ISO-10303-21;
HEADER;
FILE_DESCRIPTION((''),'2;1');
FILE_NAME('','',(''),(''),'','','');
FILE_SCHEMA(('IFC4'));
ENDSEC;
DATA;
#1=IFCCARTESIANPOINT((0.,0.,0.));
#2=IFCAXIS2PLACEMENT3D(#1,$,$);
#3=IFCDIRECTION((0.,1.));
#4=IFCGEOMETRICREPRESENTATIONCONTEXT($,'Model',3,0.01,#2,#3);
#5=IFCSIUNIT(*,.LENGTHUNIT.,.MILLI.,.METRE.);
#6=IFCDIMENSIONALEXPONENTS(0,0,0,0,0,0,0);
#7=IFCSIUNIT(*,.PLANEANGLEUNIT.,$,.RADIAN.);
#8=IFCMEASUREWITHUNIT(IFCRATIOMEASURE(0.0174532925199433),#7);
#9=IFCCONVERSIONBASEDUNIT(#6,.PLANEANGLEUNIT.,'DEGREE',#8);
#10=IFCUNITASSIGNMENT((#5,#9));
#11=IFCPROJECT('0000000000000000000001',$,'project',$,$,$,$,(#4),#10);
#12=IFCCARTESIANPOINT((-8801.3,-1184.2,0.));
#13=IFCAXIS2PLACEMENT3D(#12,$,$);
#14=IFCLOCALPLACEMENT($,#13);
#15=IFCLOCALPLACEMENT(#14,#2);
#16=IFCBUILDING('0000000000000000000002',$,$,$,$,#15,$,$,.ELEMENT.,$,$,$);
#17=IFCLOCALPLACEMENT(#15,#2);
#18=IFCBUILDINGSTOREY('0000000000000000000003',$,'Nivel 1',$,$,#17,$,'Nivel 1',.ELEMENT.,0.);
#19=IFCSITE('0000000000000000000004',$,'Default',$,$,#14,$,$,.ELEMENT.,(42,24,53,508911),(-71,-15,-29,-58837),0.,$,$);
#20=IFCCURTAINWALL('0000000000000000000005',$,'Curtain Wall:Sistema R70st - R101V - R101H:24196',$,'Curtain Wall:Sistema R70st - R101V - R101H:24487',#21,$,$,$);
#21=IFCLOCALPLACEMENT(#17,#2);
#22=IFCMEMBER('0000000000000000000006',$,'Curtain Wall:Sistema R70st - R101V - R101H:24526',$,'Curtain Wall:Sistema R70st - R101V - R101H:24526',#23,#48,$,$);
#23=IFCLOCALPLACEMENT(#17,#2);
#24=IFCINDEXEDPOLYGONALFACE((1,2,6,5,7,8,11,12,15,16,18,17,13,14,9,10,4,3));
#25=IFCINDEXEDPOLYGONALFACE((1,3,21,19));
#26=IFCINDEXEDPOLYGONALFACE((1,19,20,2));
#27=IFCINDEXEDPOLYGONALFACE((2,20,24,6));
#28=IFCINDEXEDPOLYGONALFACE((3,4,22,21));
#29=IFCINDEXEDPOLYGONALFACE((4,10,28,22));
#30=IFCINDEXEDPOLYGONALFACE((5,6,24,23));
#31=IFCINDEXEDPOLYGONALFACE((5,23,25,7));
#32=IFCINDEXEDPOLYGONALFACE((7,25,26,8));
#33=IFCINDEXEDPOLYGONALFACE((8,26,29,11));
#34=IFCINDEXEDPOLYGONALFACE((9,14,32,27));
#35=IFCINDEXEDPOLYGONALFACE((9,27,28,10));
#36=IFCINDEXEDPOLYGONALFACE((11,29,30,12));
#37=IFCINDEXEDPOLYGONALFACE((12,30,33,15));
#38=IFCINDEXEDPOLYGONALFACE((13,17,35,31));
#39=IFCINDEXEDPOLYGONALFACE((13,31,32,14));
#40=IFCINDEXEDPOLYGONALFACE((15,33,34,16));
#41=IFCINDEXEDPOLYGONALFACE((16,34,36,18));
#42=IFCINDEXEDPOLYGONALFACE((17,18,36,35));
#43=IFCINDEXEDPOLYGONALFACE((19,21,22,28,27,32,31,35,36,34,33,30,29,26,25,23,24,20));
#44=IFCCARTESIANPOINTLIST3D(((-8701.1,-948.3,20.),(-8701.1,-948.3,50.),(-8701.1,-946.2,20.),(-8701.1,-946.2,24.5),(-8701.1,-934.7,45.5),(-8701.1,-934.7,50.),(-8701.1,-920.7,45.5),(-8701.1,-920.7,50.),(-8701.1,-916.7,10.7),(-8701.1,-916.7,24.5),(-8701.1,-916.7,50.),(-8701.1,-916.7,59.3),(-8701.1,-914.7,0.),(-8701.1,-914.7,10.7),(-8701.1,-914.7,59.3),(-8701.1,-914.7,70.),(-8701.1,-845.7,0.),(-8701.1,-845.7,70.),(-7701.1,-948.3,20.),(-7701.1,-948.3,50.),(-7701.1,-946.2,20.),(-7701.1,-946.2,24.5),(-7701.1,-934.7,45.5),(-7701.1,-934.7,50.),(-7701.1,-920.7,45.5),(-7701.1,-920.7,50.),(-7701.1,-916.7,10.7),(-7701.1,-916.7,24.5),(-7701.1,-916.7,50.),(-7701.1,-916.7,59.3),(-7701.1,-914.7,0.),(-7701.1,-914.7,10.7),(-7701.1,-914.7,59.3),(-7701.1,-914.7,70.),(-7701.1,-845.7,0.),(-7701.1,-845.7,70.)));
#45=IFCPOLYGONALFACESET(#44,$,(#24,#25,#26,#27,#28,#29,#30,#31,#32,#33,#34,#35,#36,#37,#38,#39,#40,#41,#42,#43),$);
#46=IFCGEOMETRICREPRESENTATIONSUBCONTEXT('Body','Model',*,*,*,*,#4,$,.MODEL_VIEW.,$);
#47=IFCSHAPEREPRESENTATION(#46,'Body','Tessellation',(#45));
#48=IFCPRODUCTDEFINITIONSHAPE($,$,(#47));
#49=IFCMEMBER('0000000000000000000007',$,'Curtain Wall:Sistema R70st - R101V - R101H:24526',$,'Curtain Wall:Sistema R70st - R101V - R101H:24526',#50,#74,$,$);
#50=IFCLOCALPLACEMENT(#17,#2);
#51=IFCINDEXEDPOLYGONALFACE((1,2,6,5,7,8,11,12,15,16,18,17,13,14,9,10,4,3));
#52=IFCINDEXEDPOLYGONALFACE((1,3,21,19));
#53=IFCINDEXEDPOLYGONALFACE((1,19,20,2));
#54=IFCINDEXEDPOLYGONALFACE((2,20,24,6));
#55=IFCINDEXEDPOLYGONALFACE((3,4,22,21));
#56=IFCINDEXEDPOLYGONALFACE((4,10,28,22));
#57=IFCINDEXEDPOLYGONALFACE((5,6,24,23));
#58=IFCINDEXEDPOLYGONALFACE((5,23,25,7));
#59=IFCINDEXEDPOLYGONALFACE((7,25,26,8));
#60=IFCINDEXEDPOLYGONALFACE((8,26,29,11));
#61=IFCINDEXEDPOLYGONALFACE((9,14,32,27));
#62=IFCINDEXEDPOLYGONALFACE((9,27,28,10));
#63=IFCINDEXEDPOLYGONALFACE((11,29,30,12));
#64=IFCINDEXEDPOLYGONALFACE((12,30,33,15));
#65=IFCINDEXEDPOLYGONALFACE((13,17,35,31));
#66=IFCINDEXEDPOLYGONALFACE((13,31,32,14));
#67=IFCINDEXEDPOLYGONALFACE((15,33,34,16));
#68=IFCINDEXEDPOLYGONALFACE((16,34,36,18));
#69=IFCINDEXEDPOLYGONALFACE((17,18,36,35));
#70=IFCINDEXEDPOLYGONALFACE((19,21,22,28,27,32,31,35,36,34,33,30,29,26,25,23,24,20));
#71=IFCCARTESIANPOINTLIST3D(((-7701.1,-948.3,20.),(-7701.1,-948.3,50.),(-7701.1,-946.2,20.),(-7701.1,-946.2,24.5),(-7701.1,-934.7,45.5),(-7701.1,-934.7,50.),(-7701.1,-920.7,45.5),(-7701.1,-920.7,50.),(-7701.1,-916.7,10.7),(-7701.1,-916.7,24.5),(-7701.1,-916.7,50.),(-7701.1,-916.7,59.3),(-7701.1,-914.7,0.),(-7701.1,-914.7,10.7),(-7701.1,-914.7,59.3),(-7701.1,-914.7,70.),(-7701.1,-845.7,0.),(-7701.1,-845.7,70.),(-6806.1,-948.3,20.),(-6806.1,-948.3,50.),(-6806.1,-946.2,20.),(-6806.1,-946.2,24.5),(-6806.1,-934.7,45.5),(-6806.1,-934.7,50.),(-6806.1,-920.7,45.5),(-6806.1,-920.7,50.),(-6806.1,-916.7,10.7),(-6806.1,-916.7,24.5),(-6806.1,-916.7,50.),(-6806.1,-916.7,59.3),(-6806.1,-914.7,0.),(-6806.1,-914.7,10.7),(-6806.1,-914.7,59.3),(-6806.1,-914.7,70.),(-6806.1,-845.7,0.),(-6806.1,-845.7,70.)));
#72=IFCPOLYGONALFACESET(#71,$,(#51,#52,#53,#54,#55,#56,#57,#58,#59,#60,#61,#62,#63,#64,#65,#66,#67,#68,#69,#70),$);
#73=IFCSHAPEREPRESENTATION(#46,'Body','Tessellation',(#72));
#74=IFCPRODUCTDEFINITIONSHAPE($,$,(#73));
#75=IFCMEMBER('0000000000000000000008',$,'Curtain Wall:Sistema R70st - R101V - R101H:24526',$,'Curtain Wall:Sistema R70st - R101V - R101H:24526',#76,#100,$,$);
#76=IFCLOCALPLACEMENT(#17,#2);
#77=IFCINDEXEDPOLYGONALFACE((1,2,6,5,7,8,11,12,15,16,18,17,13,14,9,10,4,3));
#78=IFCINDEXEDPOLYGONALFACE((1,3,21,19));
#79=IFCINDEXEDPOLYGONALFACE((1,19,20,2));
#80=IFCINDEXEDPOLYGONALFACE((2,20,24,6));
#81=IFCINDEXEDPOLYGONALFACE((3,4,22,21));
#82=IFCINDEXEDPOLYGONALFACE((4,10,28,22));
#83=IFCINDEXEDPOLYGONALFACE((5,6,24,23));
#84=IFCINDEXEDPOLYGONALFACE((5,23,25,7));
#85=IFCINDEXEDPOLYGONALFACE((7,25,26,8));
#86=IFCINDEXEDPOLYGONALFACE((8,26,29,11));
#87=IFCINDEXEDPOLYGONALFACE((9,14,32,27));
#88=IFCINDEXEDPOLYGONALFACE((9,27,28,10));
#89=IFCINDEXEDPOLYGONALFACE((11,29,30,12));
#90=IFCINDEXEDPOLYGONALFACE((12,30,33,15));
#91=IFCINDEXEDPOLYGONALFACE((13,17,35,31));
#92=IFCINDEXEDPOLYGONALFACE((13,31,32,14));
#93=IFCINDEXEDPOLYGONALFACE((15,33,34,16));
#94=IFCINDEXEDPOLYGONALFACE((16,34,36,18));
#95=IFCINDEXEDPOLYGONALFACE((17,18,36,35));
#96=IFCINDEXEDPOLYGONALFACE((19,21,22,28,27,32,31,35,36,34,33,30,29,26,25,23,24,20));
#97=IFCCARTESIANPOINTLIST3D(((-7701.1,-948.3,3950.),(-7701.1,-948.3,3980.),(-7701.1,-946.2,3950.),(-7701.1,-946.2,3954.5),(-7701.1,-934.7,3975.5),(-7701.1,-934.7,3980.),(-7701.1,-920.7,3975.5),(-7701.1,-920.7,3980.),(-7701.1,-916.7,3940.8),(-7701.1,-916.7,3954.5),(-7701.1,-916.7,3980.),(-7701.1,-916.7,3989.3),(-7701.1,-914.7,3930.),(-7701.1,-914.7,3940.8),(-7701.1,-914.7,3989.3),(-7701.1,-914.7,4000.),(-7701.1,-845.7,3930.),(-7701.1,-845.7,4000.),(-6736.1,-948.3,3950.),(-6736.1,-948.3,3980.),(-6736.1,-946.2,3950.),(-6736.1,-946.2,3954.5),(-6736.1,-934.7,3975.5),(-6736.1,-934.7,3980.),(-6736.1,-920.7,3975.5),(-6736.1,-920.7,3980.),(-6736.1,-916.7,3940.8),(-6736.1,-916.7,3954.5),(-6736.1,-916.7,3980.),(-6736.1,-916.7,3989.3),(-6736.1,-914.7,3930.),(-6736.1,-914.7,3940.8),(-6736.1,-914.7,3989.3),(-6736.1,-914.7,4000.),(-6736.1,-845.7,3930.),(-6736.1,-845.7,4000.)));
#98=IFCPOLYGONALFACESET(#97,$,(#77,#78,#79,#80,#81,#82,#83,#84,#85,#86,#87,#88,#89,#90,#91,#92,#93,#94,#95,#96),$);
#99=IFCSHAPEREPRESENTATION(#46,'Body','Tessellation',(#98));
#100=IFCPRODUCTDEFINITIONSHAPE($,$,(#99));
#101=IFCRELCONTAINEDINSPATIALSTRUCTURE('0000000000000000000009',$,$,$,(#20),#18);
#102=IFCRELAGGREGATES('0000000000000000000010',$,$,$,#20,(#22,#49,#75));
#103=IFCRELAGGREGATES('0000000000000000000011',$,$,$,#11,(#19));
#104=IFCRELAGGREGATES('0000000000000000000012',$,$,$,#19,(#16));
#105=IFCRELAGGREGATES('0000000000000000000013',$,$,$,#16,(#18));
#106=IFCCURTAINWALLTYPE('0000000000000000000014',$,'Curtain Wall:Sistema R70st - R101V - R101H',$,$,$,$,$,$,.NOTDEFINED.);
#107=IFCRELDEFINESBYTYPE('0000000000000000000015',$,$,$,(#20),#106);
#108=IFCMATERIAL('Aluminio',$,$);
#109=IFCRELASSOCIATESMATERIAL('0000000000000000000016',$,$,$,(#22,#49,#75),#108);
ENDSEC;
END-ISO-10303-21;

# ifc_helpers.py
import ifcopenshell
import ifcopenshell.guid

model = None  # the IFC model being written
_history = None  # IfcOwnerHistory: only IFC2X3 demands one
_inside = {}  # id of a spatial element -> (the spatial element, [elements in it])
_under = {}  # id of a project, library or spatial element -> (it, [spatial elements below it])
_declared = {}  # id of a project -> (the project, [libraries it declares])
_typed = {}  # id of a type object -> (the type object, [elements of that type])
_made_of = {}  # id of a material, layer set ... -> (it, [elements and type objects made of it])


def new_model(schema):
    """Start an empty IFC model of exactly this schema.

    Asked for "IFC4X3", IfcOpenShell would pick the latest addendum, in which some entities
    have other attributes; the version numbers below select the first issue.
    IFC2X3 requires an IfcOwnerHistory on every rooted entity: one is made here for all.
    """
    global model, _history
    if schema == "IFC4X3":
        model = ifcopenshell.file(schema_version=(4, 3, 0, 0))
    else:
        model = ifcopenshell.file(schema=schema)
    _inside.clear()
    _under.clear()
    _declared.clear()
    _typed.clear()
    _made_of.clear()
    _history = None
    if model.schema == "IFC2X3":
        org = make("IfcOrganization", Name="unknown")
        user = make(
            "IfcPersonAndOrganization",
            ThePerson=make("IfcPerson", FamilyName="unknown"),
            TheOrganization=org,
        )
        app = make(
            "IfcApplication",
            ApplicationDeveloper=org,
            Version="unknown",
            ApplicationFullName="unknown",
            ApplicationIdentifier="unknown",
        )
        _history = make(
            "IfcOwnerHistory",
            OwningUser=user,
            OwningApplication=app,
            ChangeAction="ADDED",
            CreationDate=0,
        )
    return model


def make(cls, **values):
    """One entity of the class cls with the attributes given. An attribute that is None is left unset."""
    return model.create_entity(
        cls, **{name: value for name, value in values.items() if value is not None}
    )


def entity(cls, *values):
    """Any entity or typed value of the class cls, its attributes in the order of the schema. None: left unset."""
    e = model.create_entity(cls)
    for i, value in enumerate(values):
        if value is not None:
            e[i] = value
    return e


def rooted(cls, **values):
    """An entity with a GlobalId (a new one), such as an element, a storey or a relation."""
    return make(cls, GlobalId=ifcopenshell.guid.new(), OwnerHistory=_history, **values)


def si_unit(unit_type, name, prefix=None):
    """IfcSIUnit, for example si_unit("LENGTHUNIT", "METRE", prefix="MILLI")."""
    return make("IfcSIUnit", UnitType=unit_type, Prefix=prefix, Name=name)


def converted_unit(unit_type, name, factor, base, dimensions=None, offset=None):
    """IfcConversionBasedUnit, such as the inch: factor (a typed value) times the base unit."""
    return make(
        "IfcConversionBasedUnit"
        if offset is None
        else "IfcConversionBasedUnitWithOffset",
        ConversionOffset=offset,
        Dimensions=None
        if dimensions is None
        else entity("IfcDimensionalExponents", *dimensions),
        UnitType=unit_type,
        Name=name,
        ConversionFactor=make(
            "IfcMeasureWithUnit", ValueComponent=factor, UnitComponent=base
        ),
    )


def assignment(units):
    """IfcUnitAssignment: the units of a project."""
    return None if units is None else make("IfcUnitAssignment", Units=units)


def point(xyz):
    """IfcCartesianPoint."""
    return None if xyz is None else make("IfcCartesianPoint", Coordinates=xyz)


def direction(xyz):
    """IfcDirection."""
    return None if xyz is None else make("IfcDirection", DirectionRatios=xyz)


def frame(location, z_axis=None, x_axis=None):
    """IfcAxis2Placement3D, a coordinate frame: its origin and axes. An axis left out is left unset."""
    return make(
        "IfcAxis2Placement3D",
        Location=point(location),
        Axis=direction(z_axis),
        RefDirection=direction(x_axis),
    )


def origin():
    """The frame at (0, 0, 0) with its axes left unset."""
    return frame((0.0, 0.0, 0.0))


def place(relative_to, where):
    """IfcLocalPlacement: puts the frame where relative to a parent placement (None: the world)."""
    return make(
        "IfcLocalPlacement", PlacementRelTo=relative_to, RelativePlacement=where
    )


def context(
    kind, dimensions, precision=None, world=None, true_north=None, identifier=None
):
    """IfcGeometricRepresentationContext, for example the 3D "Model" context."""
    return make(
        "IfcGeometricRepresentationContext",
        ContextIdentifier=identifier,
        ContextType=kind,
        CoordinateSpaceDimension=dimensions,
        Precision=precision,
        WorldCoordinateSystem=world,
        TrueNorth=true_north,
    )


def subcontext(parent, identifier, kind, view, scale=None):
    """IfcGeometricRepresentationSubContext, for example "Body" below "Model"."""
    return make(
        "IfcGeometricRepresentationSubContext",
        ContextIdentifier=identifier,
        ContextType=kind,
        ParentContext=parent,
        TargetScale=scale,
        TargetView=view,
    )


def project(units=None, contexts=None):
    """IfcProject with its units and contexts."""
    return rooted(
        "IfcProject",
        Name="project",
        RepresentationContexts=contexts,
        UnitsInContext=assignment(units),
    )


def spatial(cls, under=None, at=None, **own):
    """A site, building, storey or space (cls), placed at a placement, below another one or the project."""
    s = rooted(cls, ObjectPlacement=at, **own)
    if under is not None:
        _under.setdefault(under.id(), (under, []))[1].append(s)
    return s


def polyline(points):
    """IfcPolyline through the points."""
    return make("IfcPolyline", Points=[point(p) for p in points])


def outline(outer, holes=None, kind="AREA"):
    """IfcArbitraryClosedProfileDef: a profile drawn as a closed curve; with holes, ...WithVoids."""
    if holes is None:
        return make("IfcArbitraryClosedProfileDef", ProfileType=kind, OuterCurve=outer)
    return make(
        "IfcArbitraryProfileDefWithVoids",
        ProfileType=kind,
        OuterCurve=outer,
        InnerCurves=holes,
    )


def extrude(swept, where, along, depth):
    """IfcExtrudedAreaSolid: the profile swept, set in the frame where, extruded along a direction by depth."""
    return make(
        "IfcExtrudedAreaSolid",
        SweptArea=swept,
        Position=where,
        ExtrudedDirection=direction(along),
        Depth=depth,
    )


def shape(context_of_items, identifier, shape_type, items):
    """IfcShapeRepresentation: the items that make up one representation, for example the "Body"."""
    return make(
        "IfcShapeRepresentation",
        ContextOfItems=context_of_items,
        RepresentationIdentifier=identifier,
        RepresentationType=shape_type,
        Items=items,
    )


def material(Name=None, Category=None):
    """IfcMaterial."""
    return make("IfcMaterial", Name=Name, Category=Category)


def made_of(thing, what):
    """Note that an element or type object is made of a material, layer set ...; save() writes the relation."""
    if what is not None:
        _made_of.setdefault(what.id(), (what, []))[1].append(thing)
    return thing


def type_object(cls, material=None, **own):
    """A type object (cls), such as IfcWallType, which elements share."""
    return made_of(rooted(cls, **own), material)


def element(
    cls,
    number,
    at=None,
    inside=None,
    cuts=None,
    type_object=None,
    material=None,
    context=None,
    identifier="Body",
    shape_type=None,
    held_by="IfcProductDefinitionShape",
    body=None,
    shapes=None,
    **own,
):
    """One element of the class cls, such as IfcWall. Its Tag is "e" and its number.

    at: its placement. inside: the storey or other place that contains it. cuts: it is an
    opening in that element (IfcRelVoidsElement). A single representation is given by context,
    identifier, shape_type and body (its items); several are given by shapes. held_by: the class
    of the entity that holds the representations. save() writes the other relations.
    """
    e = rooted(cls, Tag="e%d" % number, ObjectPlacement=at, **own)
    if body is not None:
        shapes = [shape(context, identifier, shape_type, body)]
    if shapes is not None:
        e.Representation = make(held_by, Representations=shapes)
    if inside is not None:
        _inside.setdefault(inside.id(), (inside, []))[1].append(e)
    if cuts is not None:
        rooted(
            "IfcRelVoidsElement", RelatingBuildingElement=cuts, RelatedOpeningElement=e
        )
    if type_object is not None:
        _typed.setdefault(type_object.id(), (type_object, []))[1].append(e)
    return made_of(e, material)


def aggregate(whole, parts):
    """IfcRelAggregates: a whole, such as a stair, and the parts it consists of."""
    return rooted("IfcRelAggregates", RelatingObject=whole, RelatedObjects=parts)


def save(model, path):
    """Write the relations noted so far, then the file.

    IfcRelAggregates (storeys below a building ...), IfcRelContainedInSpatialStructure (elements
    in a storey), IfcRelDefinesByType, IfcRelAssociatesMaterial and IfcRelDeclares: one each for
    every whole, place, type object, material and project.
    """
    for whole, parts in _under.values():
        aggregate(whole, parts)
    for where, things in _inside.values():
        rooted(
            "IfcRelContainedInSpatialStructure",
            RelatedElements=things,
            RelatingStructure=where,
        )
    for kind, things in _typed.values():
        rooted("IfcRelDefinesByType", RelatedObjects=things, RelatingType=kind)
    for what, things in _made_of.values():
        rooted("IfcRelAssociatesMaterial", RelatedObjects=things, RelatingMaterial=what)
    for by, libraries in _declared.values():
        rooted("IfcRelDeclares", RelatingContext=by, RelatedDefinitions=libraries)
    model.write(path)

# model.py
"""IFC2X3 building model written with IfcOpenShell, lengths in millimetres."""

from ifc_helpers import new_model, entity, si_unit, converted_unit, direction, frame, origin, place, context, subcontext, project, spatial, polyline, outline, extrude, material, type_object, element, aggregate, save


model = new_model("IFC2X3")

# Units and contexts
model_context = context("Model", 3, precision=0.01, world=origin(), true_north=direction((0.0, 1.0)))
body_context = subcontext(model_context, "Body", "Model", "MODEL_VIEW")
ifc_project = project(units=[si_unit("LENGTHUNIT", "METRE", prefix="MILLI"), converted_unit("PLANEANGLEUNIT", "DEGREE", entity("IfcRatioMeasure", 0.0174532925199433), si_unit("PLANEANGLEUNIT", "RADIAN"), dimensions=[0, 0, 0, 0, 0, 0, 0])], contexts=[model_context])

# Site, building, storey
site_placement = place(None, frame((-8801.3, -1184.2, 0.0)))
site = spatial("IfcSite", under=ifc_project, at=site_placement, Name="Default", CompositionType="ELEMENT", RefLatitude=(42, 24, 53, 508911), RefLongitude=(-71, -15, -29, -58837), RefElevation=0.0)
building_placement = place(site_placement, origin())
building = spatial("IfcBuilding", under=site, at=building_placement, CompositionType="ELEMENT")
storey_placement = place(building_placement, origin())
storey = spatial("IfcBuildingStorey", under=building, at=storey_placement, Name="Nivel 1", LongName="Nivel 1", CompositionType="ELEMENT", Elevation=0.0)

# Curtain wall, members
curtain_wall_type = type_object("IfcCurtainWallType", Name="Curtain Wall:Sistema R70st - R101V - R101H", PredefinedType="NOTDEFINED")
curtain_wall_placement = place(storey_placement, origin())
curtain_wall = element("IfcCurtainWall", 1, at=curtain_wall_placement, inside=storey, type_object=curtain_wall_type, Name="Curtain Wall:Sistema R70st - R101V - R101H:24196", ObjectType="Curtain Wall:Sistema R70st - R101V - R101H:24487")
ifc_material = material(Name="Aluminio")
member_1_placement = place(curtain_wall_placement, origin())
member_1 = element("IfcMember", 2, at=member_1_placement, material=ifc_material, Name="Curtain Wall:Sistema R70st - R101V - R101H:24526", ObjectType="Curtain Wall:Sistema R70st - R101V - R101H:24526", context=body_context, shape_type="SweptSolid", body=[
    extrude(outline(polyline([(-13.3, -30.7), (16.7, -30.7), (16.7, -28.6), (12.2, -28.6), (12.2, 0.9), (25.9, 0.9), (25.9, 2.9), (36.7, 2.9), (36.7, 71.9), (-33.3, 71.9), (-33.3, 2.9), (-22.6, 2.9), (-22.6, 0.9), (-13.3, 0.9), (-13.3, -3.1), (-8.8, -3.1), (-8.8, -17.1), (-13.3, -17.1), (-13.3, -30.7)])), frame((-8701.1, -917.6, 36.7), z_axis=(1.0, 0.0, 0.0), x_axis=(0.0, 0.0, -1.0)), (0.0, 0.0, 1.0), 1000.0),
])
member_2_placement = place(curtain_wall_placement, origin())
member_2 = element("IfcMember", 3, at=member_2_placement, material=ifc_material, Name="Curtain Wall:Sistema R70st - R101V - R101H:24526", ObjectType="Curtain Wall:Sistema R70st - R101V - R101H:24526", context=body_context, shape_type="SweptSolid", body=[
    extrude(outline(polyline([(-13.3, -30.7), (16.7, -30.7), (16.7, -28.6), (12.2, -28.6), (12.2, 0.9), (25.9, 0.9), (25.9, 2.9), (36.7, 2.9), (36.7, 71.9), (-33.3, 71.9), (-33.3, 2.9), (-22.6, 2.9), (-22.6, 0.9), (-13.3, 0.9), (-13.3, -3.1), (-8.8, -3.1), (-8.8, -17.1), (-13.3, -17.1), (-13.3, -30.7)])), frame((-7701.1, -917.6, 36.7), z_axis=(1.0, 0.0, 0.0), x_axis=(0.0, 0.0, -1.0)), (0.0, 0.0, 1.0), 895.0),
])
member_3_placement = place(curtain_wall_placement, origin())
member_3 = element("IfcMember", 4, at=member_3_placement, material=ifc_material, Name="Curtain Wall:Sistema R70st - R101V - R101H:24526", ObjectType="Curtain Wall:Sistema R70st - R101V - R101H:24526", context=body_context, shape_type="SweptSolid", body=[
    extrude(outline(polyline([(-33.3, -71.9), (36.7, -71.9), (36.7, -2.9), (25.9, -2.9), (25.9, -0.9), (12.2, -0.9), (12.2, 28.6), (16.7, 28.6), (16.7, 30.7), (-13.3, 30.7), (-13.3, 17.1), (-8.8, 17.1), (-8.8, 3.1), (-13.3, 3.1), (-13.3, -0.9), (-22.6, -0.9), (-22.6, -2.9), (-33.3, -2.9), (-33.3, -71.9)])), frame((-6736.1, -917.6, 3966.7), z_axis=(-1.0, 0.0, 0.0), x_axis=(0.0, 0.0, -1.0)), (0.0, 0.0, 1.0), 965.0),
])
aggregate(curtain_wall, [member_1, member_2, member_3])

save(model, "model.ifc")
